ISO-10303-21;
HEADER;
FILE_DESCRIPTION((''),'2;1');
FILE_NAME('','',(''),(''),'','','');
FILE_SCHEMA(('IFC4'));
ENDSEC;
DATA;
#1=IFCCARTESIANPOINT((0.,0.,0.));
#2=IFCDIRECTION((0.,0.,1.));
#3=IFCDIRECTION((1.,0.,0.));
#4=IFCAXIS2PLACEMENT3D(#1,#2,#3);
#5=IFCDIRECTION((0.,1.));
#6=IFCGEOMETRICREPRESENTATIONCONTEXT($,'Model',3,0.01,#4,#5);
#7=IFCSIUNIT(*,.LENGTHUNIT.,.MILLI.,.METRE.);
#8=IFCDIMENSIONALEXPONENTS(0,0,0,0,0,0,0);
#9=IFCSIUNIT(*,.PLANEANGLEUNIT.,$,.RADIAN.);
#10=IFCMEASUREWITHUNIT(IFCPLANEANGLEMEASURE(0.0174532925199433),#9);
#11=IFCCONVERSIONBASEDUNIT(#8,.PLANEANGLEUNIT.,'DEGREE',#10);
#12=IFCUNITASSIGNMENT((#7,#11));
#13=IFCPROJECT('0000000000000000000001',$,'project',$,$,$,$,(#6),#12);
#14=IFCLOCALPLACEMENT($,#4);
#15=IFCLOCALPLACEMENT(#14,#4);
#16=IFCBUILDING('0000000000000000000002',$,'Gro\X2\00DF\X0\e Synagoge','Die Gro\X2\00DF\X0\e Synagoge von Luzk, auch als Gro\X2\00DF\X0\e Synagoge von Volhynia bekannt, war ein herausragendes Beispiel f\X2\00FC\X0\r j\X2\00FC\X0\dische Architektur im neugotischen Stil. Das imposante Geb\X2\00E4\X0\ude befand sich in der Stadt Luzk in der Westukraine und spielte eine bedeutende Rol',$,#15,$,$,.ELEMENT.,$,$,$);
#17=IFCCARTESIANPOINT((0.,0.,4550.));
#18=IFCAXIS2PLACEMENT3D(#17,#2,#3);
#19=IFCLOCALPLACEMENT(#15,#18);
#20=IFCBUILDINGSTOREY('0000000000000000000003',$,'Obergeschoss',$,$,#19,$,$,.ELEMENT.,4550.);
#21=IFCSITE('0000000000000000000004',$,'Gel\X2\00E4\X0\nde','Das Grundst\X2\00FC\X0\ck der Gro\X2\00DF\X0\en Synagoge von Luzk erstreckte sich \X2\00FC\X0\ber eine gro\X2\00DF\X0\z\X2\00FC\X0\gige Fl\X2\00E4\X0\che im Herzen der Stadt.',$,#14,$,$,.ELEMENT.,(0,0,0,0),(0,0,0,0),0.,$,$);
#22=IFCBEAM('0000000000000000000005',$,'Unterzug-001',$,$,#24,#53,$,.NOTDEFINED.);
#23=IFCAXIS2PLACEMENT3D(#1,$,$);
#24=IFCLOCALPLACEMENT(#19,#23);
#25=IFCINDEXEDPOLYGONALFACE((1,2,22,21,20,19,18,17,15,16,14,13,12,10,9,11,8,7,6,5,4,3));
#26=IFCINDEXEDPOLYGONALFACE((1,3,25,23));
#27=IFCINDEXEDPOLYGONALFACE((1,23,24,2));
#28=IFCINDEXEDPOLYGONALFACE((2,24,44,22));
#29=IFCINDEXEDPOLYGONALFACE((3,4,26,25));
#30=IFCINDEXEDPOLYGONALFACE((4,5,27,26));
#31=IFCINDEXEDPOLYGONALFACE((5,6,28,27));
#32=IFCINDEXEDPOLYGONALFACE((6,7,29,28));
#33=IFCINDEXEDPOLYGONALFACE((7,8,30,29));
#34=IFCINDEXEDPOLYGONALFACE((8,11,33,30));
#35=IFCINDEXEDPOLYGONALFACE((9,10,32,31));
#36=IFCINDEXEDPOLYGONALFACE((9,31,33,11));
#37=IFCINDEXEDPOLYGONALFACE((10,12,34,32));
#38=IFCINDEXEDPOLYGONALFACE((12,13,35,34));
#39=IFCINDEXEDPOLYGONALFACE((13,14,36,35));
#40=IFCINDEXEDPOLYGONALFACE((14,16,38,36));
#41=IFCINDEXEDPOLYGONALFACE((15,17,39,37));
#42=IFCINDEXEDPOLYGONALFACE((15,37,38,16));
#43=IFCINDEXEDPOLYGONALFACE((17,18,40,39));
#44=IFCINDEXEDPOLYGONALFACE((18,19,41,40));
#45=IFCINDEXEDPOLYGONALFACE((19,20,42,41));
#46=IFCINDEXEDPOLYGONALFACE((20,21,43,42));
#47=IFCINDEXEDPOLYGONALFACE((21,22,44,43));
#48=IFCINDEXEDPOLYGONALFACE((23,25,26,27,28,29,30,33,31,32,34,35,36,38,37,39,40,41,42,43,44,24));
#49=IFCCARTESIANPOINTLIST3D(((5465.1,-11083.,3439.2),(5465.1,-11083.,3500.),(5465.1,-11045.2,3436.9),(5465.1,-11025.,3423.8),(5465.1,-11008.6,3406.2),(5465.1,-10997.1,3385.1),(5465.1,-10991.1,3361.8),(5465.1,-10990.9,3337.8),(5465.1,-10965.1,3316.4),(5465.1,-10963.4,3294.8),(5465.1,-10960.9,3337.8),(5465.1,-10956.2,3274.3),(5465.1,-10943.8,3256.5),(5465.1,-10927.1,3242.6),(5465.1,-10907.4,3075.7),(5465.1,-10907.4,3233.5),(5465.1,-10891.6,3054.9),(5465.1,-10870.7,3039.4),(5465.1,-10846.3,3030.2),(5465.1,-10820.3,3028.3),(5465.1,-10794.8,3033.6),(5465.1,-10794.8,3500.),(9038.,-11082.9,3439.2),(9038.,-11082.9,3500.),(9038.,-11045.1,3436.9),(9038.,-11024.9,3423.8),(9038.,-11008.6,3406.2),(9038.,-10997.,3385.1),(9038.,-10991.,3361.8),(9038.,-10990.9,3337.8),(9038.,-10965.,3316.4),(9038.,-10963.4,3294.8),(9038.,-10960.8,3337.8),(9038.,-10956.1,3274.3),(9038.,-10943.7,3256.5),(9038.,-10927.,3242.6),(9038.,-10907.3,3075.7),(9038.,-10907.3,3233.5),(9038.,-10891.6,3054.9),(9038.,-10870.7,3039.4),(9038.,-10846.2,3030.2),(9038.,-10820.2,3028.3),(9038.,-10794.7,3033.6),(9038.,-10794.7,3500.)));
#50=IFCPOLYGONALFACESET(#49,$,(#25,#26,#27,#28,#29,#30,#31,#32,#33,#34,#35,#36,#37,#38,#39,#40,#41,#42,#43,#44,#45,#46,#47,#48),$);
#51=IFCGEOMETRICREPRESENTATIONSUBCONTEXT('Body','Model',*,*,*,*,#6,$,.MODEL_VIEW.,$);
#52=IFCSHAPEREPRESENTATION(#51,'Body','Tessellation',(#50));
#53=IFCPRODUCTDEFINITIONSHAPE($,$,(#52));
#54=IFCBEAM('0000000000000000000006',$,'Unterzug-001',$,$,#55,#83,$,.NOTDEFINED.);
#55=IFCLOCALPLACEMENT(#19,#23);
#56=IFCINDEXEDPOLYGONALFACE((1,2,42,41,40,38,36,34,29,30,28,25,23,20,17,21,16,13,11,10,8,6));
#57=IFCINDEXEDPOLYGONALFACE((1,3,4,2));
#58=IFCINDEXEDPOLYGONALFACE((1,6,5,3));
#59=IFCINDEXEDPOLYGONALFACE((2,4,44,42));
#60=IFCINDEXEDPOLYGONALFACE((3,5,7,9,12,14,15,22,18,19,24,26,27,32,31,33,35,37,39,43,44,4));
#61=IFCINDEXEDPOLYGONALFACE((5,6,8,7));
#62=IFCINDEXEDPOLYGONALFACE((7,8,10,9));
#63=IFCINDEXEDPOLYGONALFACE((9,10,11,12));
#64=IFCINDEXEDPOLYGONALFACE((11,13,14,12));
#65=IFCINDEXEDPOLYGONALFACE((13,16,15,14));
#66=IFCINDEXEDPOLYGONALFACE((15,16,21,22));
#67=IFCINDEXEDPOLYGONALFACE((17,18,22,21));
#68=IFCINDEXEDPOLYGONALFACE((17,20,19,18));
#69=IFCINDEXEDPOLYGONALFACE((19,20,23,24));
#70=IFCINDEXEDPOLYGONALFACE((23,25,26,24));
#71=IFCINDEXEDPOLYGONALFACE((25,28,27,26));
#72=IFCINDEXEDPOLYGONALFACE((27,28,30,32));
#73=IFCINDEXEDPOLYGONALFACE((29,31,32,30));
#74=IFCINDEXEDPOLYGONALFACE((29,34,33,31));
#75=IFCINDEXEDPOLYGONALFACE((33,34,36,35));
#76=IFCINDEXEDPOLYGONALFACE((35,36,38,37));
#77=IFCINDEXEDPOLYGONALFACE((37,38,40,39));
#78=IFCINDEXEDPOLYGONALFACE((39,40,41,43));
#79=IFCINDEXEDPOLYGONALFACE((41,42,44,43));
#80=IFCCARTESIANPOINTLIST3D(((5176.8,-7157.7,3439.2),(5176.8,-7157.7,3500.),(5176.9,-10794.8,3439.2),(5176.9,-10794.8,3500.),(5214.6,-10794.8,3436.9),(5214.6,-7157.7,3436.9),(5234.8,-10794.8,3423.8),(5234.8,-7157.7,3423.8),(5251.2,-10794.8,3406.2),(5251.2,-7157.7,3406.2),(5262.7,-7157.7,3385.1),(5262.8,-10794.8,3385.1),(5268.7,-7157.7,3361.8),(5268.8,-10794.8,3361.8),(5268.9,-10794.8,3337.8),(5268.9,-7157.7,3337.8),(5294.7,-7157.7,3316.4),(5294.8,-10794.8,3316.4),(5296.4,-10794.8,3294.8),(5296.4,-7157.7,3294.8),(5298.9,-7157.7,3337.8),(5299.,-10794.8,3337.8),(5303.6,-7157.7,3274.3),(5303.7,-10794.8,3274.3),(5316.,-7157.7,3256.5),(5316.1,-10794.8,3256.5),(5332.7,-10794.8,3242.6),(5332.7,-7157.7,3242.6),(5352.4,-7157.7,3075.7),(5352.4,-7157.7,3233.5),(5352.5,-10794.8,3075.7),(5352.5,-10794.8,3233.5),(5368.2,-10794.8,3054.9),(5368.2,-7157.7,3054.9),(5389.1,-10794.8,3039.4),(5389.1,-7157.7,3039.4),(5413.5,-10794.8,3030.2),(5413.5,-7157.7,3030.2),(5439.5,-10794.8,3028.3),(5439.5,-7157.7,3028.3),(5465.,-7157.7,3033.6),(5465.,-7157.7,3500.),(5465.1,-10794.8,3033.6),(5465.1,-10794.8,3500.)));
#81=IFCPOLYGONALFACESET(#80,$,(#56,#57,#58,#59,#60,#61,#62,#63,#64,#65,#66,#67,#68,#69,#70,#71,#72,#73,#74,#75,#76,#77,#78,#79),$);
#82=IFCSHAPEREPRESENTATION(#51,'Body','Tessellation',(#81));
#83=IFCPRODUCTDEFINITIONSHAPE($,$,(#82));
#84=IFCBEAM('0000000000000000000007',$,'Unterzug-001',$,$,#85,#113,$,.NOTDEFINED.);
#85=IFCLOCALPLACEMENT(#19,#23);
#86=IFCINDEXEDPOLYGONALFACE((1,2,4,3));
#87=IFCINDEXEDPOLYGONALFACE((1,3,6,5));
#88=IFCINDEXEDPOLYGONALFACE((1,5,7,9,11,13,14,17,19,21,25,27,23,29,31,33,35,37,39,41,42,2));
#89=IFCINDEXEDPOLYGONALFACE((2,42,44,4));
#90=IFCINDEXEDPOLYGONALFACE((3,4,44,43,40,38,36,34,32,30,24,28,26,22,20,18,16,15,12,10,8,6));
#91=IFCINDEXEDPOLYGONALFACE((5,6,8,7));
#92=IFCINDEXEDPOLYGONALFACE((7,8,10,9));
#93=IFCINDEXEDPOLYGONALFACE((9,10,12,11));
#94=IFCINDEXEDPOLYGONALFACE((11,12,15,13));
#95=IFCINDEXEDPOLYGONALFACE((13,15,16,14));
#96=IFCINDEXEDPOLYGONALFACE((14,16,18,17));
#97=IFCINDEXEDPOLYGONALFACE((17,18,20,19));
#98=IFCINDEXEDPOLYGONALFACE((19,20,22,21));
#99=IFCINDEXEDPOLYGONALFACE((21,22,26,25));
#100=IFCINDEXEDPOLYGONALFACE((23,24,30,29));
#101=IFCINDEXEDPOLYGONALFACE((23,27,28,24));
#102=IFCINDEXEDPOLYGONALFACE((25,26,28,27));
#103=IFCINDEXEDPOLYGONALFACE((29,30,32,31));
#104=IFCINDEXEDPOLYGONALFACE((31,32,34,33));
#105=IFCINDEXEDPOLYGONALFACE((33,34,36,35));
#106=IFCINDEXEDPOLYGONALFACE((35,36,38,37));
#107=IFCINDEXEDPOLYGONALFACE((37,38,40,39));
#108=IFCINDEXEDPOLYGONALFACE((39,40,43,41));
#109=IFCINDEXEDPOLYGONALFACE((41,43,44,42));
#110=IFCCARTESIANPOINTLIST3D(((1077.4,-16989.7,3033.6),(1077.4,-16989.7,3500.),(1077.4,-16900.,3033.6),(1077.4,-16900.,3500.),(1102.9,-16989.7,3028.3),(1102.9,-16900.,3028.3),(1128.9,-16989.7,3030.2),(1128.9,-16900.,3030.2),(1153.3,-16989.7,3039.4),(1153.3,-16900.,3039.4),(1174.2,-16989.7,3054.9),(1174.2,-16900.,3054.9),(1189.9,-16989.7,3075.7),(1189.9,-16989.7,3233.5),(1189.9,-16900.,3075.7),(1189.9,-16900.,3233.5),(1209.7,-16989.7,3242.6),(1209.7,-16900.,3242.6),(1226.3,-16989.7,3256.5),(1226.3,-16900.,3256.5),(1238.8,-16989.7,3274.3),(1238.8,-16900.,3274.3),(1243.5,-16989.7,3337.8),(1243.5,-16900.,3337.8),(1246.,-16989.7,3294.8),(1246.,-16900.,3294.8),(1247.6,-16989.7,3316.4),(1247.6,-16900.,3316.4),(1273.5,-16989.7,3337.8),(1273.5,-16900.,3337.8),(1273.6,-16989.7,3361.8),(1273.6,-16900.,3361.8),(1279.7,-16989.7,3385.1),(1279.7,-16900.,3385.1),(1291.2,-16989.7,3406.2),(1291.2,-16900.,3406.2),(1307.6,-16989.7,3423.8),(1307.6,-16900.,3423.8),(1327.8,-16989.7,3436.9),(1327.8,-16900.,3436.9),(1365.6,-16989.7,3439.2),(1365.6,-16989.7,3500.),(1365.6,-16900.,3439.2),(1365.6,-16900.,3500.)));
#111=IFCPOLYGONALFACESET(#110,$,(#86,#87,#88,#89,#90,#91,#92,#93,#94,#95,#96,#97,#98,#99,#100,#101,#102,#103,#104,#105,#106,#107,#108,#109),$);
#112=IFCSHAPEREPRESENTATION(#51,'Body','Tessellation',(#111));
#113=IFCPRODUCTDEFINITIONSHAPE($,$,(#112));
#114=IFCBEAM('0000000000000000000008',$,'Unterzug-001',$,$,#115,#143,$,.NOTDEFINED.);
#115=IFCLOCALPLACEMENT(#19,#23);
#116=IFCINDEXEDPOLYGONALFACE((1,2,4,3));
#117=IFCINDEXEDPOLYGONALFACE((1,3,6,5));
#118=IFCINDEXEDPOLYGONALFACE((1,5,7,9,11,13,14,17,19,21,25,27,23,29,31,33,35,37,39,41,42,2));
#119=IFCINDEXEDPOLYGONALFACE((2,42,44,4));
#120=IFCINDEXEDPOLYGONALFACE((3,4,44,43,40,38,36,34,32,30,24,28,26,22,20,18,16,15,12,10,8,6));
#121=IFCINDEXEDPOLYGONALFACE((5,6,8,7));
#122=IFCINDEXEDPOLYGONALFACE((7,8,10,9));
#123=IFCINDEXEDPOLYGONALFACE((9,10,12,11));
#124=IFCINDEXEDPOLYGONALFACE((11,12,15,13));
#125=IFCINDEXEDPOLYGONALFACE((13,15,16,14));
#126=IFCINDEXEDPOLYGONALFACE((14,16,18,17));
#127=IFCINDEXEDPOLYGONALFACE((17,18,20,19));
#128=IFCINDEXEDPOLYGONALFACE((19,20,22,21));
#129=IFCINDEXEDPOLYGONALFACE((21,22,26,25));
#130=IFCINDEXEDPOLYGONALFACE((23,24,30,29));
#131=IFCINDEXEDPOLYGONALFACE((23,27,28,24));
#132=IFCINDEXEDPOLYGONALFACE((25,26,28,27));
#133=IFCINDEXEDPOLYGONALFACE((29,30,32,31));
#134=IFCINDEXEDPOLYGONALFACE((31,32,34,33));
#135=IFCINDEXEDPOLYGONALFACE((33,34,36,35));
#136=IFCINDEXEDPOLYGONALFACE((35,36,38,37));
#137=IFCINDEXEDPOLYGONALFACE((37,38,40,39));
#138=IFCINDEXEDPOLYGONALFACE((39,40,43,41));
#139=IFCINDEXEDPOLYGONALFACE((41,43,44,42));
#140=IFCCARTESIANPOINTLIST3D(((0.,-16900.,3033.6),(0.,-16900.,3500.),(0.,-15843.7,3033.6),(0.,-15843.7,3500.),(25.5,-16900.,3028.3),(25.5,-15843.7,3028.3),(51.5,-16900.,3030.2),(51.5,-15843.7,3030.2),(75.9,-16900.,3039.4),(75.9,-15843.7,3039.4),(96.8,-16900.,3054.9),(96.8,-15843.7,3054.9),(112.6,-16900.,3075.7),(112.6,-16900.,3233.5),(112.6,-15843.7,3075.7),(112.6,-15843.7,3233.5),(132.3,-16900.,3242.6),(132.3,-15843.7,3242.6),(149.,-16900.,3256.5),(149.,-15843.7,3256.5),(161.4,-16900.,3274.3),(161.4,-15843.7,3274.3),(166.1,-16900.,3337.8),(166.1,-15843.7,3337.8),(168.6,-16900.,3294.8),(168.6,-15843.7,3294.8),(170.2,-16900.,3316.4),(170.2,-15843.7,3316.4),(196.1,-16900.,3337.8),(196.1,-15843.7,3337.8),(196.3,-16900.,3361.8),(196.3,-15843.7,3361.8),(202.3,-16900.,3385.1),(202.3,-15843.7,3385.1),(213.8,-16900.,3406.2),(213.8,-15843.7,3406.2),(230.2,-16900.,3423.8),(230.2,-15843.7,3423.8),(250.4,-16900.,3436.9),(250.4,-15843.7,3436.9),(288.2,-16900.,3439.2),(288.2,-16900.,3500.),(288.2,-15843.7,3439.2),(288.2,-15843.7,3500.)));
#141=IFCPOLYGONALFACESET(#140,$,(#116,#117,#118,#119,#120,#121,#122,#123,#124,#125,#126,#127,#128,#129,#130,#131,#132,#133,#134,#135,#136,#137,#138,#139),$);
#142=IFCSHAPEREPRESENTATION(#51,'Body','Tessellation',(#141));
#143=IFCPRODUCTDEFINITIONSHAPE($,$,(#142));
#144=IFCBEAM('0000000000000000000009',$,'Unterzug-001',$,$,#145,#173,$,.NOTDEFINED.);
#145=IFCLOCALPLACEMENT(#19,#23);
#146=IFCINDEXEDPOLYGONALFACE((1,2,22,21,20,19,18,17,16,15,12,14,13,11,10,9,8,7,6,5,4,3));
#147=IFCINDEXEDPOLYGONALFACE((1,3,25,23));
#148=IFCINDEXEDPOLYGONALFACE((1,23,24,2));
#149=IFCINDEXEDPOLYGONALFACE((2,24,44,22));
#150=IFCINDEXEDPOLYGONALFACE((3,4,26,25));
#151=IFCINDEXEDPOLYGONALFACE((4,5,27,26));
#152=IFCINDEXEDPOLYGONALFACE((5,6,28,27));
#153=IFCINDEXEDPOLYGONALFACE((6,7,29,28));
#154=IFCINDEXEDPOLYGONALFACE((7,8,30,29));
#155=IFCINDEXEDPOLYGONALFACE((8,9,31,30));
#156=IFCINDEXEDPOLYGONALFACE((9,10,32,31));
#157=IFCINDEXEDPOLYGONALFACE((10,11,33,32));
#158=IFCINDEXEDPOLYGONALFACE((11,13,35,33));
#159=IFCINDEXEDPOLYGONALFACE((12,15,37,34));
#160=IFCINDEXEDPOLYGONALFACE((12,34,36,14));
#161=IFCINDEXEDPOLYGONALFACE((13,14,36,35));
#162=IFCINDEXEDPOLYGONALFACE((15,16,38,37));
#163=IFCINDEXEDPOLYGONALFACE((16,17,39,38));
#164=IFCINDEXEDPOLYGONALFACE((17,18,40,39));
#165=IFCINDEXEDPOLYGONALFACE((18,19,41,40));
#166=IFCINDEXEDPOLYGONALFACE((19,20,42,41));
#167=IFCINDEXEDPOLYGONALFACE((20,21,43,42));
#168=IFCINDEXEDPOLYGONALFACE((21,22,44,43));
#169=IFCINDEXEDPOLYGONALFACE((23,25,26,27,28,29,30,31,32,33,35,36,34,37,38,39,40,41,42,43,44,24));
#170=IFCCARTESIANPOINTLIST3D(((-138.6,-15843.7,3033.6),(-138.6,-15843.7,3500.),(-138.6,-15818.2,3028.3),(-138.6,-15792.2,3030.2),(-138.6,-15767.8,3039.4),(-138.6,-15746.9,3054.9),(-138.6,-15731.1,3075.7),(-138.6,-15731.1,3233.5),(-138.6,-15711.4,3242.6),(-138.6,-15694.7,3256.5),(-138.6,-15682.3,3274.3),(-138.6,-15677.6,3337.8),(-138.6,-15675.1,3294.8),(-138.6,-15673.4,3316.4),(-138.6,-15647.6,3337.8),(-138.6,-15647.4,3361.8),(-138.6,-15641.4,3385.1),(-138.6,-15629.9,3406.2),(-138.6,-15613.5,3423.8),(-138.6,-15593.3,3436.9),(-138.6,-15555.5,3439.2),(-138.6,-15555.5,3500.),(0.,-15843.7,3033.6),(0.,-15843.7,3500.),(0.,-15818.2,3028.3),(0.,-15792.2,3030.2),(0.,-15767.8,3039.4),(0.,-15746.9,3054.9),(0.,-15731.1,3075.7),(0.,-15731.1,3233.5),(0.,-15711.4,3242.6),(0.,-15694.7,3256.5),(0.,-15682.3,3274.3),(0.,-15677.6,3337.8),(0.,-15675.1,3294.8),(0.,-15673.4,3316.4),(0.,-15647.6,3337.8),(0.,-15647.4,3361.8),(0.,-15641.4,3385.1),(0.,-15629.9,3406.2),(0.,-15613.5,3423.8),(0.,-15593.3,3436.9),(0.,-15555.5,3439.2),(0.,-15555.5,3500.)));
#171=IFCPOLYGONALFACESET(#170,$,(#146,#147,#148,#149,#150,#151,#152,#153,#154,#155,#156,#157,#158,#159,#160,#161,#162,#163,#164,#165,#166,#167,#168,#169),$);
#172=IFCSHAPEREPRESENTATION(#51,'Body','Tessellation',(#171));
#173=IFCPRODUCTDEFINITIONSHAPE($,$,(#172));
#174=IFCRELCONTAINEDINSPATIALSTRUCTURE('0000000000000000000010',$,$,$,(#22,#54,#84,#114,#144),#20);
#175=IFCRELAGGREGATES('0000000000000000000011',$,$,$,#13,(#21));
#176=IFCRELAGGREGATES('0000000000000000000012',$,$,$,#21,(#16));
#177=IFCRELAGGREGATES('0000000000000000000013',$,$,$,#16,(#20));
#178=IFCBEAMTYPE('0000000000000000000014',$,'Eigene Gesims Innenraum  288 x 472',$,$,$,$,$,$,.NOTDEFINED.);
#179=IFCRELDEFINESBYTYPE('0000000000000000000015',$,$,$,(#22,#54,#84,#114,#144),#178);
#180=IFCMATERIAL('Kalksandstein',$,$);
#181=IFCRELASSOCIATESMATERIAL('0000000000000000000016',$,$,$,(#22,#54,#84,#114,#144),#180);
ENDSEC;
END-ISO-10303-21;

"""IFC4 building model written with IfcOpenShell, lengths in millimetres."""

from ifc_helpers import new_model, entity, si_unit, converted_unit, direction, frame, origin_with_axes, place, context, subcontext, project, spatial, line, arc, indexed_curve, outline, extrude, material, material_profile, profile_set, type_object, element, save


model = new_model("IFC4")

# Units and contexts
model_context = context("Model", 3, precision=0.01, world=origin_with_axes(), true_north=direction((0.0, 1.0)))
body_context = subcontext(model_context, "Body", "Model", "MODEL_VIEW")
ifc_project = project(units=[si_unit("LENGTHUNIT", "METRE", prefix="MILLI"), converted_unit("PLANEANGLEUNIT", "DEGREE", entity("IfcPlaneAngleMeasure", 0.0174532925199433), si_unit("PLANEANGLEUNIT", "RADIAN"), dimensions=[0, 0, 0, 0, 0, 0, 0])], contexts=[model_context])

# Site, building, storey
site_placement = place(None, origin_with_axes())
site = spatial("IfcSite", under=ifc_project, at=site_placement, Name="Gelände", Description="Das Grundstück der Großen Synagoge von Luzk erstreckte sich über eine großzügige Fläche im Herzen der Stadt.", CompositionType="ELEMENT", RefLatitude=(0, 0, 0, 0), RefLongitude=(0, 0, 0, 0), RefElevation=0.0)
building_placement = place(site_placement, origin_with_axes())
building = spatial("IfcBuilding", under=site, at=building_placement, Name="Große Synagoge", Description="Die Große Synagoge von Luzk, auch als Große Synagoge von Volhynia bekannt, war ein herausragendes Beispiel für jüdische Architektur im neugotischen Stil. Das imposante Gebäude befand sich in der Stadt Luzk in der Westukraine und spielte eine bedeutende Rol", CompositionType="ELEMENT")
storey_placement = place(building_placement, frame((0.0, 0.0, 4550.0), z_axis=(0.0, 0.0, 1.0), x_axis=(1.0, 0.0, 0.0)))
storey = spatial("IfcBuildingStorey", under=building, at=storey_placement, Name="Obergeschoss", CompositionType="ELEMENT", Elevation=4550.0)

# Beams
ifc_material_1 = material(Name="Kalksandstein")
ifc_material_profile_1 = material_profile(ifc_material_1, outline(indexed_curve([(0.0, 0.0), (0.0, -466.4), (64.0, -466.1), (112.6, -424.3), (112.6, -266.5), (161.4, -225.7), (166.1, -162.2), (196.1, -162.2), (207.4, -104.0), (250.4, -63.1), (288.2, -60.8), (288.2, 0.0)], segments=[line(1, 2), arc(2, 3, 4), line(4, 5), arc(5, 6, 7), line(7, 8), arc(8, 9, 10), line(10, 11, 12, 1)])), Name="Kalksandstein")
ifc_profile_set_1 = profile_set([ifc_material_profile_1], Name="Eigene Gesims Innenraum ")
beam_type_1 = type_object("IfcBeamType", Name="Eigene Gesims Innenraum  288 x 472", PredefinedType="NOTDEFINED")
beam_1_placement = place(storey_placement, frame((5465.1, -10794.8, 3500.0), z_axis=(0.0, 0.0, 1.0), x_axis=(0.00002, -1.0, 0.0)))
element("IfcBeam", 1, at=beam_1_placement, inside=storey, type_object=beam_type_1, material=ifc_profile_set_1, Name="Unterzug-001", PredefinedType="NOTDEFINED", context=body_context, shape_type="SweptSolid", body=[
    extrude(outline(indexed_curve([(0.0, 0.0), (0.0, -466.4), (64.0, -466.1), (112.6, -424.3), (112.6, -266.5), (161.4, -225.7), (166.1, -162.2), (196.1, -162.2), (207.4, -104.0), (250.4, -63.1), (288.2, -60.8), (288.2, 0.0)], segments=[line(1, 2), arc(2, 3, 4), line(4, 5), arc(5, 6, 7), line(7, 8), arc(8, 9, 10), line(10, 11, 12, 1)])), frame((0.0, 3572.9, 0.0), z_axis=(0.0, -1.0, 0.0), x_axis=(1.0, 0.0, 0.0)), (0.0, 0.0, 1.0), 3572.9),
])
beam_2_placement = place(storey_placement, frame((5465.1, -10794.8, 3500.0), z_axis=(0.0, 0.0, 1.0), x_axis=(1.0, 0.000017, 0.0)))
element("IfcBeam", 2, at=beam_2_placement, inside=storey, type_object=beam_type_1, material=ifc_profile_set_1, Name="Unterzug-001", PredefinedType="NOTDEFINED", context=body_context, shape_type="SweptSolid", body=[
    extrude(outline(indexed_curve([(0.0, 0.0), (0.0, -466.4), (64.0, -466.1), (112.6, -424.3), (112.6, -266.5), (161.4, -225.7), (166.1, -162.2), (196.1, -162.2), (207.4, -104.0), (250.4, -63.1), (288.2, -60.8), (288.2, 0.0)], segments=[line(1, 2), arc(2, 3, 4), line(4, 5), arc(5, 6, 7), line(7, 8), arc(8, 9, 10), line(10, 11, 12, 1)])), frame((0.0, 3637.1, 0.0), z_axis=(0.0, 1.0, 0.0), x_axis=(-1.0, 0.0, 0.0)), (0.0, 0.0, -1.0), 3637.1),
])
beam_3_placement = place(storey_placement, frame((1077.4, -16900.0, 3500.0), z_axis=(0.0, 0.0, 1.0), x_axis=(-1.0, 0.0, 0.0)))
element("IfcBeam", 3, at=beam_3_placement, inside=storey, type_object=beam_type_1, material=ifc_profile_set_1, Name="Unterzug-001", PredefinedType="NOTDEFINED", context=body_context, shape_type="SweptSolid", body=[
    extrude(outline(indexed_curve([(0.0, 0.0), (0.0, -466.4), (64.0, -466.1), (112.6, -424.3), (112.6, -266.5), (161.4, -225.7), (166.1, -162.2), (196.1, -162.2), (207.4, -104.0), (250.4, -63.1), (288.2, -60.8), (288.2, 0.0)], segments=[line(1, 2), arc(2, 3, 4), line(4, 5), arc(5, 6, 7), line(7, 8), arc(8, 9, 10), line(10, 11, 12, 1)])), frame((0.0, 89.7, 0.0), z_axis=(0.0, 1.0, 0.0), x_axis=(-1.0, 0.0, 0.0)), (0.0, 0.0, -1.0), 89.7),
])
beam_4_placement = place(storey_placement, frame((0.0, -15843.7, 3500.0), z_axis=(0.0, 0.0, 1.0), x_axis=(-1.0, 0.0, 0.0)))
element("IfcBeam", 4, at=beam_4_placement, inside=storey, type_object=beam_type_1, material=ifc_profile_set_1, Name="Unterzug-001", PredefinedType="NOTDEFINED", context=body_context, shape_type="SweptSolid", body=[
    extrude(outline(indexed_curve([(0.0, 0.0), (0.0, -466.4), (64.0, -466.1), (112.6, -424.3), (112.6, -266.5), (161.4, -225.7), (166.1, -162.2), (196.1, -162.2), (207.4, -104.0), (250.4, -63.1), (288.2, -60.8), (288.2, 0.0)], segments=[line(1, 2), arc(2, 3, 4), line(4, 5), arc(5, 6, 7), line(7, 8), arc(8, 9, 10), line(10, 11, 12, 1)])), frame((0.0, 1056.3, 0.0), z_axis=(0.0, 1.0, 0.0), x_axis=(-1.0, 0.0, 0.0)), (0.0, 0.0, -1.0), 1056.3),
])
beam_5_placement = place(storey_placement, frame((-138.6, -15843.7, 3500.0), z_axis=(0.0, 0.0, 1.0), x_axis=(0.0, -1.0, 0.0)))
element("IfcBeam", 5, at=beam_5_placement, inside=storey, type_object=beam_type_1, material=ifc_profile_set_1, Name="Unterzug-001", PredefinedType="NOTDEFINED", context=body_context, shape_type="SweptSolid", body=[
    extrude(outline(indexed_curve([(0.0, 0.0), (0.0, -466.4), (64.0, -466.1), (112.6, -424.3), (112.6, -266.5), (161.4, -225.7), (166.1, -162.2), (196.1, -162.2), (207.4, -104.0), (250.4, -63.1), (288.2, -60.8), (288.2, 0.0)], segments=[line(1, 2), arc(2, 3, 4), line(4, 5), arc(5, 6, 7), line(7, 8), arc(8, 9, 10), line(10, 11, 12, 1)])), frame((0.0, 138.6, 0.0), z_axis=(0.0, 1.0, 0.0), x_axis=(-1.0, 0.0, 0.0)), (0.0, 0.0, -1.0), 138.6),
])

save(model, "model.ifc")
